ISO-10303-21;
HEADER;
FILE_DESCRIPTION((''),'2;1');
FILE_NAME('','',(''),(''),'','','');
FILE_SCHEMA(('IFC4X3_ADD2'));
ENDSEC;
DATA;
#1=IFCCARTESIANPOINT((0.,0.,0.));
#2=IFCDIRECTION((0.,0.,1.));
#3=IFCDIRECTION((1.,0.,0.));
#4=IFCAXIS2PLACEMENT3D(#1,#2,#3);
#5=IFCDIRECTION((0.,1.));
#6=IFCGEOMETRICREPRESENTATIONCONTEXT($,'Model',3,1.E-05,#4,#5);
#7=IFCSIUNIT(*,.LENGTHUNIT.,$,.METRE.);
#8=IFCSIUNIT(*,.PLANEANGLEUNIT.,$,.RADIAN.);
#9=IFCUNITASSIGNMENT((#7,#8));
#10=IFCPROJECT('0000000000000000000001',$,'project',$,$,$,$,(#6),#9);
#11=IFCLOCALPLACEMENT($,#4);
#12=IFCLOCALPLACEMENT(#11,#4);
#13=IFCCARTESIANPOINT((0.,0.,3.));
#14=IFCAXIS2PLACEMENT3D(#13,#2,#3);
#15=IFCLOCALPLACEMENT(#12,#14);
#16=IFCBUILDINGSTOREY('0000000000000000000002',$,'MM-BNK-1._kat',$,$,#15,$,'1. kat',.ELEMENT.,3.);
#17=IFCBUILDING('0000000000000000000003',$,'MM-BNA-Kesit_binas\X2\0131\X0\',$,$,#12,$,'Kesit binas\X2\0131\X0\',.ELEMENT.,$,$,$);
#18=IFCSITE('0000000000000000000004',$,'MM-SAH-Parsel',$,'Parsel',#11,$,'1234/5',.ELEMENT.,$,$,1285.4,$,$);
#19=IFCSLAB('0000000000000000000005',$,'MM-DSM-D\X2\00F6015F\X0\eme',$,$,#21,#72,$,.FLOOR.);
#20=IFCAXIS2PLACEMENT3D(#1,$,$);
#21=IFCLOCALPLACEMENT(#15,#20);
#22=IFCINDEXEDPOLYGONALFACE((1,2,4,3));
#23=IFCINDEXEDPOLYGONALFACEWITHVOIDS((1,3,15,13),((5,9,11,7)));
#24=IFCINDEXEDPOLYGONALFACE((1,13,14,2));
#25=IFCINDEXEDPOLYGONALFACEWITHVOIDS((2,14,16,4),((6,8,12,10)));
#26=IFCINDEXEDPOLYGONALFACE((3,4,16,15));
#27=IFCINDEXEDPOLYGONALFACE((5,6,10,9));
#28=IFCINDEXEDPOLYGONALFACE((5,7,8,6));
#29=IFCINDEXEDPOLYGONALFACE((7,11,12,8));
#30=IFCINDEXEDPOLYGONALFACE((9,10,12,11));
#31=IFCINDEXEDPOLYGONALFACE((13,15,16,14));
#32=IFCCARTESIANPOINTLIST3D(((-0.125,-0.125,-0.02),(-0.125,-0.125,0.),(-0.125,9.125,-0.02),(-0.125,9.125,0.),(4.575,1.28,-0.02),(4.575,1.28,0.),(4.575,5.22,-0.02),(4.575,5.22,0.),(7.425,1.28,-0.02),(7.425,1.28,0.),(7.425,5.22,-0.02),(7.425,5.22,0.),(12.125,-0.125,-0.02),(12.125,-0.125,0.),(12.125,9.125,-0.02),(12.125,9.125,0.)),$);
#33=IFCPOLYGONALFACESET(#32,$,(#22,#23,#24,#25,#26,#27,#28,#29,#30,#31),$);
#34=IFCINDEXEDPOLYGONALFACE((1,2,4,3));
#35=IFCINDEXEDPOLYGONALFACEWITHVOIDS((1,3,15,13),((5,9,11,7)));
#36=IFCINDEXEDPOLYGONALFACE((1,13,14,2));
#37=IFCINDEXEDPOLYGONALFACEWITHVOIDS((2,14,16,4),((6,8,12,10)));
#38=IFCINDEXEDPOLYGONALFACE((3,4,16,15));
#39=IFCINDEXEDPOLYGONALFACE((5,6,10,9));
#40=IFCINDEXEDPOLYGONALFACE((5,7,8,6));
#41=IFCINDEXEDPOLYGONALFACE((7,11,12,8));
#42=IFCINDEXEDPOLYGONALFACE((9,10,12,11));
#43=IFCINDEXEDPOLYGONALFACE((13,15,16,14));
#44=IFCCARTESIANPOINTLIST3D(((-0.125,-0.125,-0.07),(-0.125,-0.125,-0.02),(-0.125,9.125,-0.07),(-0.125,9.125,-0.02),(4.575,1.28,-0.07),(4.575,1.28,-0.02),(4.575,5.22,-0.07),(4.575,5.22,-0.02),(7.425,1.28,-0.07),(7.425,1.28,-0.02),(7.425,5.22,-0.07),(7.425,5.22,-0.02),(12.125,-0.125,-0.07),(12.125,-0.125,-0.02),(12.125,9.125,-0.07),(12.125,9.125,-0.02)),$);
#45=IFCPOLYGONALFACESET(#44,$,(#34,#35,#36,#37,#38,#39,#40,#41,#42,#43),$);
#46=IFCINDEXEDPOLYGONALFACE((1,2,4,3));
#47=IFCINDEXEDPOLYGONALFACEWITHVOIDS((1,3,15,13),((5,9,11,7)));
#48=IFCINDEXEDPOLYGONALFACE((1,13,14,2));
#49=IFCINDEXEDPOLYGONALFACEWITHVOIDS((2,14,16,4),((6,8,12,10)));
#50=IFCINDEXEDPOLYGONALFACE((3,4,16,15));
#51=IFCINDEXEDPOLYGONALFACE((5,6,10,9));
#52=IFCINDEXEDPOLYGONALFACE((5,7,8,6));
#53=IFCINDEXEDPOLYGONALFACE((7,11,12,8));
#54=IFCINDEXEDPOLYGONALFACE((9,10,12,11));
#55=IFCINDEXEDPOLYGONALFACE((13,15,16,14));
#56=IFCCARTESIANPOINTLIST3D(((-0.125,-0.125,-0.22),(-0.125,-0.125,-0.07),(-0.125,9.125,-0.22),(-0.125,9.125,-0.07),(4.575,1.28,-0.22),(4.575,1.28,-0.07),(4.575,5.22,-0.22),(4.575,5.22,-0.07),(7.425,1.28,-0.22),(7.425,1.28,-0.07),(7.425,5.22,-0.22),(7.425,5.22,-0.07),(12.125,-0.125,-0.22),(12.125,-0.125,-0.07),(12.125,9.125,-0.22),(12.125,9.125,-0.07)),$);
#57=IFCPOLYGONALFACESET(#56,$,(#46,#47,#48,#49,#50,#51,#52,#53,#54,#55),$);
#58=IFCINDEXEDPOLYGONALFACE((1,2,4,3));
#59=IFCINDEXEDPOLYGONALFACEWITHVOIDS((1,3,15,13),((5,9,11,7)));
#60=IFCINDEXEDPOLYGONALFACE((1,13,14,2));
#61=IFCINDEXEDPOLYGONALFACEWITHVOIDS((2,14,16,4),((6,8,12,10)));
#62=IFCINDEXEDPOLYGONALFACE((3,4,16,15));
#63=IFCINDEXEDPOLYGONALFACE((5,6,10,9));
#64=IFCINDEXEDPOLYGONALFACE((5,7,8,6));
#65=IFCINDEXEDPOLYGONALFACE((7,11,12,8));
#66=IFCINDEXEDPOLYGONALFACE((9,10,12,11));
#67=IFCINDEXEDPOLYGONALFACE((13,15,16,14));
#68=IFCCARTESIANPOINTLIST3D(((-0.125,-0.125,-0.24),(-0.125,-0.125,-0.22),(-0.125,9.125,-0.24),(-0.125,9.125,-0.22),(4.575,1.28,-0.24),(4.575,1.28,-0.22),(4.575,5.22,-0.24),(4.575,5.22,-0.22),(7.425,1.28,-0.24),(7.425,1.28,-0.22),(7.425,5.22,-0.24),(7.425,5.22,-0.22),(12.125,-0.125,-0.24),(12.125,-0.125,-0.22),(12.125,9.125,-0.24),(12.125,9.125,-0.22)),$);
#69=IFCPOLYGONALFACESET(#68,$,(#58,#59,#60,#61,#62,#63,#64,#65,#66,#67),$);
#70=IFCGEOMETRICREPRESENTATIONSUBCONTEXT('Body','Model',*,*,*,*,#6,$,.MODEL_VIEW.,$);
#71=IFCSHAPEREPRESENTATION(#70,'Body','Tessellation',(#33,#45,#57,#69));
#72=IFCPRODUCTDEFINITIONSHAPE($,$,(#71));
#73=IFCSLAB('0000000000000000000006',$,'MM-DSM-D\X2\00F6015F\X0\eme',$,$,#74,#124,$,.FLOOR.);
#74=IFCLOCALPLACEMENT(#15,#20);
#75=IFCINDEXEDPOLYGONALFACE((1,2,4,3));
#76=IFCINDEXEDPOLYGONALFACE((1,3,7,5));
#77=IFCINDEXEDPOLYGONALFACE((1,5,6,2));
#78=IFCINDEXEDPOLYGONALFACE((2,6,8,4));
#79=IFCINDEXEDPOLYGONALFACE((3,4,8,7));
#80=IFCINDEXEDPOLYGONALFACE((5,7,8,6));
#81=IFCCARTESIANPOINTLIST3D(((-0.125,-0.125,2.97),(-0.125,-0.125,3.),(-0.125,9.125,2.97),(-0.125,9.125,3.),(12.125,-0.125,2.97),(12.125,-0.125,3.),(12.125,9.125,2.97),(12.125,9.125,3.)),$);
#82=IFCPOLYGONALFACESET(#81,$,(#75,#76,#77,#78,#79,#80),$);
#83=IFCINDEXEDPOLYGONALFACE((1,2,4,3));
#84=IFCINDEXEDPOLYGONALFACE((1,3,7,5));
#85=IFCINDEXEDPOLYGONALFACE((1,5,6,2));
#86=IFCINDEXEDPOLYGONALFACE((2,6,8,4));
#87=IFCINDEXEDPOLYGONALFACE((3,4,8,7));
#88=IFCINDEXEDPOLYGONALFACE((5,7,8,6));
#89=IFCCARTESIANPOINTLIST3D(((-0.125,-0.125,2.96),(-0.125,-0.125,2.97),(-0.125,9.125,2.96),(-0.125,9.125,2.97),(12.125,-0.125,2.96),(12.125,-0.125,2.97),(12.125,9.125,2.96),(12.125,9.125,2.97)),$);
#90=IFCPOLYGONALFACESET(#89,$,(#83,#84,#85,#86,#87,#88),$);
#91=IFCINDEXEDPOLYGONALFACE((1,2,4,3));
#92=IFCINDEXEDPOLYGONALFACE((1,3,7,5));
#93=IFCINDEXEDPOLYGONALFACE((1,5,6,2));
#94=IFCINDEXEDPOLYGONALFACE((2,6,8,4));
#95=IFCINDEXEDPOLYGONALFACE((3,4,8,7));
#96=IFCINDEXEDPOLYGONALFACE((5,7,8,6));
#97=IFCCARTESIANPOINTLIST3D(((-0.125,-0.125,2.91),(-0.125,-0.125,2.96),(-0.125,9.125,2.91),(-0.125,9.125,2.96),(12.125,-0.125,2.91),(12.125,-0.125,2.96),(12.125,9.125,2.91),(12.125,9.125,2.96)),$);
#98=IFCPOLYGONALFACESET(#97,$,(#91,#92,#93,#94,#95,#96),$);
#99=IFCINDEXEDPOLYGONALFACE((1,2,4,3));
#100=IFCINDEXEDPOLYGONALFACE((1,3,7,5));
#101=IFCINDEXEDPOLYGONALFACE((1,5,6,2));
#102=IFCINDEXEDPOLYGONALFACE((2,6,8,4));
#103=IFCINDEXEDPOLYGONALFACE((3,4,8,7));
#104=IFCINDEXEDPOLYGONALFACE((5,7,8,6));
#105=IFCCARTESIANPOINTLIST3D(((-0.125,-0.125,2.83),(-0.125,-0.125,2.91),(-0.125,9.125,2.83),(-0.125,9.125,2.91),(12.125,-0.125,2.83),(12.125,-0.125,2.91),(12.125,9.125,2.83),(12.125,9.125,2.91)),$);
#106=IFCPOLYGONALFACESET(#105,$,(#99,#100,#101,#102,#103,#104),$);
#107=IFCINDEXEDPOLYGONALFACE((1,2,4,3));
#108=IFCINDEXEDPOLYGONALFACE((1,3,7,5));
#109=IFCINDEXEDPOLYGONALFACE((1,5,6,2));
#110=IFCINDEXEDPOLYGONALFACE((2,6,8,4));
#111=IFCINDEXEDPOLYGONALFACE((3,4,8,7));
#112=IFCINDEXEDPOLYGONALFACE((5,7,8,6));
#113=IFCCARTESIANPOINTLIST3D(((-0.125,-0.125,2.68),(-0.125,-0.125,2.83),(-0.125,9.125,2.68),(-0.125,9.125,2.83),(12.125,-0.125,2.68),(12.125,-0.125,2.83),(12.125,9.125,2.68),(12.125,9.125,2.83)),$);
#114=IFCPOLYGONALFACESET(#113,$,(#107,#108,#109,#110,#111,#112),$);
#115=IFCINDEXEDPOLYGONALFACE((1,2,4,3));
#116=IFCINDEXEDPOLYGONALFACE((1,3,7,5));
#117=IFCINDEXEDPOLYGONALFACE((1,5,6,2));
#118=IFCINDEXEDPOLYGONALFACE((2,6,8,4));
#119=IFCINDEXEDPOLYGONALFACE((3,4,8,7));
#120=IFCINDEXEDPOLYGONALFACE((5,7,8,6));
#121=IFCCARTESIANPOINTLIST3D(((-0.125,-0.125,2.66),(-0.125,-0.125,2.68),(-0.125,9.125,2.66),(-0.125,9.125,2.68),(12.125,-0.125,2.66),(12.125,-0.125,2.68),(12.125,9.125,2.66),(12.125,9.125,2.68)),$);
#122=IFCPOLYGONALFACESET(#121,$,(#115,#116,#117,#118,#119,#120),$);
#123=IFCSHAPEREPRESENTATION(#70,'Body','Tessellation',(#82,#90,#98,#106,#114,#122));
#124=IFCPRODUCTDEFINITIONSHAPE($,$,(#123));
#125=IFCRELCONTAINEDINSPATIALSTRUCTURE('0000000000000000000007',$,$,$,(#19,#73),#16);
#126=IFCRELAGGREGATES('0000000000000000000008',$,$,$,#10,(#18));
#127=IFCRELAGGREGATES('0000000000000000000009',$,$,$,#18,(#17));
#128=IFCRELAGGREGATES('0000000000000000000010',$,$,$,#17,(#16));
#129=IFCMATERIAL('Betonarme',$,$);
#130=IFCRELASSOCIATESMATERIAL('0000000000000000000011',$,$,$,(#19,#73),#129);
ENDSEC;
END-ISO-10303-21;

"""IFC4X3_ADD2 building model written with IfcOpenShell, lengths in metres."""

from ifc_helpers import new_model, si_unit, direction, frame, origin_with_axes, place, context, subcontext, project, spatial, polyline, outline, extrude, material, element, save


model = new_model("IFC4X3_ADD2")

# Units and contexts
model_context = context("Model", 3, precision=1e-05, world=origin_with_axes(), true_north=direction((0.0, 1.0)))
body_context = subcontext(model_context, "Body", "Model", "MODEL_VIEW")
ifc_project = project(units=[si_unit("LENGTHUNIT", "METRE"), si_unit("PLANEANGLEUNIT", "RADIAN")], contexts=[model_context])

# Site, building, storey
site_placement = place(None, origin_with_axes())
site = spatial("IfcSite", under=ifc_project, at=site_placement, Name="MM-SAH-Parsel", ObjectType="Parsel", LongName="1234/5", CompositionType="ELEMENT", RefElevation=1285.4)
building_placement = place(site_placement, origin_with_axes())
building = spatial("IfcBuilding", under=site, at=building_placement, Name="MM-BNA-Kesit_binası", LongName="Kesit binası", CompositionType="ELEMENT")
storey_placement = place(building_placement, frame((0.0, 0.0, 3.0), z_axis=(0.0, 0.0, 1.0), x_axis=(1.0, 0.0, 0.0)))
storey = spatial("IfcBuildingStorey", under=building, at=storey_placement, Name="MM-BNK-1._kat", LongName="1. kat", CompositionType="ELEMENT", Elevation=3.0)

# Shared definitions
ifc_material_1 = material(Name="Betonarme")

# Slab, opening
slab_1_placement = place(storey_placement, origin_with_axes())
slab_1 = element("IfcSlab", 1, at=slab_1_placement, inside=storey, material=ifc_material_1, Name="MM-DSM-Döşeme", PredefinedType="FLOOR", context=body_context, shape_type="SweptSolid", body=[
    extrude(outline(polyline([(-0.125, -0.125), (12.125, -0.125), (12.125, 9.125), (-0.125, 9.125), (-0.125, -0.125)])), frame((0.0, 0.0, -0.02)), (0.0, 0.0, 1.0), 0.02),
    extrude(outline(polyline([(-0.125, -0.125), (12.125, -0.125), (12.125, 9.125), (-0.125, 9.125), (-0.125, -0.125)])), frame((0.0, 0.0, -0.07)), (0.0, 0.0, 1.0), 0.05),
    extrude(outline(polyline([(-0.125, -0.125), (12.125, -0.125), (12.125, 9.125), (-0.125, 9.125), (-0.125, -0.125)])), frame((0.0, 0.0, -0.22)), (0.0, 0.0, 1.0), 0.15),
    extrude(outline(polyline([(-0.125, -0.125), (12.125, -0.125), (12.125, 9.125), (-0.125, 9.125), (-0.125, -0.125)])), frame((0.0, 0.0, -0.24)), (0.0, 0.0, 1.0), 0.02),
])
opening_1_placement = place(storey_placement, origin_with_axes())
element("IfcOpeningElement", 2, at=opening_1_placement, cuts=slab_1, PredefinedType="OPENING", context=body_context, shape_type="SweptSolid", body=[
    extrude(outline(polyline([(4.575, 1.28), (4.575, 5.22), (7.425, 5.22), (7.425, 1.28), (4.575, 1.28)])), frame((0.0, 0.0, -0.24)), (0.0, 0.0, 1.0), 0.24),
])

# Slab
slab_2_placement = place(storey_placement, origin_with_axes())
element("IfcSlab", 3, at=slab_2_placement, inside=storey, material=ifc_material_1, Name="MM-DSM-Döşeme", PredefinedType="FLOOR", context=body_context, shape_type="SweptSolid", body=[
    extrude(outline(polyline([(-0.125, -0.125), (12.125, -0.125), (12.125, 9.125), (-0.125, 9.125), (-0.125, -0.125)])), frame((0.0, 0.0, 2.97)), (0.0, 0.0, 1.0), 0.03),
    extrude(outline(polyline([(-0.125, -0.125), (12.125, -0.125), (12.125, 9.125), (-0.125, 9.125), (-0.125, -0.125)])), frame((0.0, 0.0, 2.96)), (0.0, 0.0, 1.0), 0.01),
    extrude(outline(polyline([(-0.125, -0.125), (12.125, -0.125), (12.125, 9.125), (-0.125, 9.125), (-0.125, -0.125)])), frame((0.0, 0.0, 2.91)), (0.0, 0.0, 1.0), 0.05),
    extrude(outline(polyline([(-0.125, -0.125), (12.125, -0.125), (12.125, 9.125), (-0.125, 9.125), (-0.125, -0.125)])), frame((0.0, 0.0, 2.83)), (0.0, 0.0, 1.0), 0.08),
    extrude(outline(polyline([(-0.125, -0.125), (12.125, -0.125), (12.125, 9.125), (-0.125, 9.125), (-0.125, -0.125)])), frame((0.0, 0.0, 2.68)), (0.0, 0.0, 1.0), 0.15),
    extrude(outline(polyline([(-0.125, -0.125), (12.125, -0.125), (12.125, 9.125), (-0.125, 9.125), (-0.125, -0.125)])), frame((0.0, 0.0, 2.66)), (0.0, 0.0, 1.0), 0.02),
])

save(model, "model.ifc")
